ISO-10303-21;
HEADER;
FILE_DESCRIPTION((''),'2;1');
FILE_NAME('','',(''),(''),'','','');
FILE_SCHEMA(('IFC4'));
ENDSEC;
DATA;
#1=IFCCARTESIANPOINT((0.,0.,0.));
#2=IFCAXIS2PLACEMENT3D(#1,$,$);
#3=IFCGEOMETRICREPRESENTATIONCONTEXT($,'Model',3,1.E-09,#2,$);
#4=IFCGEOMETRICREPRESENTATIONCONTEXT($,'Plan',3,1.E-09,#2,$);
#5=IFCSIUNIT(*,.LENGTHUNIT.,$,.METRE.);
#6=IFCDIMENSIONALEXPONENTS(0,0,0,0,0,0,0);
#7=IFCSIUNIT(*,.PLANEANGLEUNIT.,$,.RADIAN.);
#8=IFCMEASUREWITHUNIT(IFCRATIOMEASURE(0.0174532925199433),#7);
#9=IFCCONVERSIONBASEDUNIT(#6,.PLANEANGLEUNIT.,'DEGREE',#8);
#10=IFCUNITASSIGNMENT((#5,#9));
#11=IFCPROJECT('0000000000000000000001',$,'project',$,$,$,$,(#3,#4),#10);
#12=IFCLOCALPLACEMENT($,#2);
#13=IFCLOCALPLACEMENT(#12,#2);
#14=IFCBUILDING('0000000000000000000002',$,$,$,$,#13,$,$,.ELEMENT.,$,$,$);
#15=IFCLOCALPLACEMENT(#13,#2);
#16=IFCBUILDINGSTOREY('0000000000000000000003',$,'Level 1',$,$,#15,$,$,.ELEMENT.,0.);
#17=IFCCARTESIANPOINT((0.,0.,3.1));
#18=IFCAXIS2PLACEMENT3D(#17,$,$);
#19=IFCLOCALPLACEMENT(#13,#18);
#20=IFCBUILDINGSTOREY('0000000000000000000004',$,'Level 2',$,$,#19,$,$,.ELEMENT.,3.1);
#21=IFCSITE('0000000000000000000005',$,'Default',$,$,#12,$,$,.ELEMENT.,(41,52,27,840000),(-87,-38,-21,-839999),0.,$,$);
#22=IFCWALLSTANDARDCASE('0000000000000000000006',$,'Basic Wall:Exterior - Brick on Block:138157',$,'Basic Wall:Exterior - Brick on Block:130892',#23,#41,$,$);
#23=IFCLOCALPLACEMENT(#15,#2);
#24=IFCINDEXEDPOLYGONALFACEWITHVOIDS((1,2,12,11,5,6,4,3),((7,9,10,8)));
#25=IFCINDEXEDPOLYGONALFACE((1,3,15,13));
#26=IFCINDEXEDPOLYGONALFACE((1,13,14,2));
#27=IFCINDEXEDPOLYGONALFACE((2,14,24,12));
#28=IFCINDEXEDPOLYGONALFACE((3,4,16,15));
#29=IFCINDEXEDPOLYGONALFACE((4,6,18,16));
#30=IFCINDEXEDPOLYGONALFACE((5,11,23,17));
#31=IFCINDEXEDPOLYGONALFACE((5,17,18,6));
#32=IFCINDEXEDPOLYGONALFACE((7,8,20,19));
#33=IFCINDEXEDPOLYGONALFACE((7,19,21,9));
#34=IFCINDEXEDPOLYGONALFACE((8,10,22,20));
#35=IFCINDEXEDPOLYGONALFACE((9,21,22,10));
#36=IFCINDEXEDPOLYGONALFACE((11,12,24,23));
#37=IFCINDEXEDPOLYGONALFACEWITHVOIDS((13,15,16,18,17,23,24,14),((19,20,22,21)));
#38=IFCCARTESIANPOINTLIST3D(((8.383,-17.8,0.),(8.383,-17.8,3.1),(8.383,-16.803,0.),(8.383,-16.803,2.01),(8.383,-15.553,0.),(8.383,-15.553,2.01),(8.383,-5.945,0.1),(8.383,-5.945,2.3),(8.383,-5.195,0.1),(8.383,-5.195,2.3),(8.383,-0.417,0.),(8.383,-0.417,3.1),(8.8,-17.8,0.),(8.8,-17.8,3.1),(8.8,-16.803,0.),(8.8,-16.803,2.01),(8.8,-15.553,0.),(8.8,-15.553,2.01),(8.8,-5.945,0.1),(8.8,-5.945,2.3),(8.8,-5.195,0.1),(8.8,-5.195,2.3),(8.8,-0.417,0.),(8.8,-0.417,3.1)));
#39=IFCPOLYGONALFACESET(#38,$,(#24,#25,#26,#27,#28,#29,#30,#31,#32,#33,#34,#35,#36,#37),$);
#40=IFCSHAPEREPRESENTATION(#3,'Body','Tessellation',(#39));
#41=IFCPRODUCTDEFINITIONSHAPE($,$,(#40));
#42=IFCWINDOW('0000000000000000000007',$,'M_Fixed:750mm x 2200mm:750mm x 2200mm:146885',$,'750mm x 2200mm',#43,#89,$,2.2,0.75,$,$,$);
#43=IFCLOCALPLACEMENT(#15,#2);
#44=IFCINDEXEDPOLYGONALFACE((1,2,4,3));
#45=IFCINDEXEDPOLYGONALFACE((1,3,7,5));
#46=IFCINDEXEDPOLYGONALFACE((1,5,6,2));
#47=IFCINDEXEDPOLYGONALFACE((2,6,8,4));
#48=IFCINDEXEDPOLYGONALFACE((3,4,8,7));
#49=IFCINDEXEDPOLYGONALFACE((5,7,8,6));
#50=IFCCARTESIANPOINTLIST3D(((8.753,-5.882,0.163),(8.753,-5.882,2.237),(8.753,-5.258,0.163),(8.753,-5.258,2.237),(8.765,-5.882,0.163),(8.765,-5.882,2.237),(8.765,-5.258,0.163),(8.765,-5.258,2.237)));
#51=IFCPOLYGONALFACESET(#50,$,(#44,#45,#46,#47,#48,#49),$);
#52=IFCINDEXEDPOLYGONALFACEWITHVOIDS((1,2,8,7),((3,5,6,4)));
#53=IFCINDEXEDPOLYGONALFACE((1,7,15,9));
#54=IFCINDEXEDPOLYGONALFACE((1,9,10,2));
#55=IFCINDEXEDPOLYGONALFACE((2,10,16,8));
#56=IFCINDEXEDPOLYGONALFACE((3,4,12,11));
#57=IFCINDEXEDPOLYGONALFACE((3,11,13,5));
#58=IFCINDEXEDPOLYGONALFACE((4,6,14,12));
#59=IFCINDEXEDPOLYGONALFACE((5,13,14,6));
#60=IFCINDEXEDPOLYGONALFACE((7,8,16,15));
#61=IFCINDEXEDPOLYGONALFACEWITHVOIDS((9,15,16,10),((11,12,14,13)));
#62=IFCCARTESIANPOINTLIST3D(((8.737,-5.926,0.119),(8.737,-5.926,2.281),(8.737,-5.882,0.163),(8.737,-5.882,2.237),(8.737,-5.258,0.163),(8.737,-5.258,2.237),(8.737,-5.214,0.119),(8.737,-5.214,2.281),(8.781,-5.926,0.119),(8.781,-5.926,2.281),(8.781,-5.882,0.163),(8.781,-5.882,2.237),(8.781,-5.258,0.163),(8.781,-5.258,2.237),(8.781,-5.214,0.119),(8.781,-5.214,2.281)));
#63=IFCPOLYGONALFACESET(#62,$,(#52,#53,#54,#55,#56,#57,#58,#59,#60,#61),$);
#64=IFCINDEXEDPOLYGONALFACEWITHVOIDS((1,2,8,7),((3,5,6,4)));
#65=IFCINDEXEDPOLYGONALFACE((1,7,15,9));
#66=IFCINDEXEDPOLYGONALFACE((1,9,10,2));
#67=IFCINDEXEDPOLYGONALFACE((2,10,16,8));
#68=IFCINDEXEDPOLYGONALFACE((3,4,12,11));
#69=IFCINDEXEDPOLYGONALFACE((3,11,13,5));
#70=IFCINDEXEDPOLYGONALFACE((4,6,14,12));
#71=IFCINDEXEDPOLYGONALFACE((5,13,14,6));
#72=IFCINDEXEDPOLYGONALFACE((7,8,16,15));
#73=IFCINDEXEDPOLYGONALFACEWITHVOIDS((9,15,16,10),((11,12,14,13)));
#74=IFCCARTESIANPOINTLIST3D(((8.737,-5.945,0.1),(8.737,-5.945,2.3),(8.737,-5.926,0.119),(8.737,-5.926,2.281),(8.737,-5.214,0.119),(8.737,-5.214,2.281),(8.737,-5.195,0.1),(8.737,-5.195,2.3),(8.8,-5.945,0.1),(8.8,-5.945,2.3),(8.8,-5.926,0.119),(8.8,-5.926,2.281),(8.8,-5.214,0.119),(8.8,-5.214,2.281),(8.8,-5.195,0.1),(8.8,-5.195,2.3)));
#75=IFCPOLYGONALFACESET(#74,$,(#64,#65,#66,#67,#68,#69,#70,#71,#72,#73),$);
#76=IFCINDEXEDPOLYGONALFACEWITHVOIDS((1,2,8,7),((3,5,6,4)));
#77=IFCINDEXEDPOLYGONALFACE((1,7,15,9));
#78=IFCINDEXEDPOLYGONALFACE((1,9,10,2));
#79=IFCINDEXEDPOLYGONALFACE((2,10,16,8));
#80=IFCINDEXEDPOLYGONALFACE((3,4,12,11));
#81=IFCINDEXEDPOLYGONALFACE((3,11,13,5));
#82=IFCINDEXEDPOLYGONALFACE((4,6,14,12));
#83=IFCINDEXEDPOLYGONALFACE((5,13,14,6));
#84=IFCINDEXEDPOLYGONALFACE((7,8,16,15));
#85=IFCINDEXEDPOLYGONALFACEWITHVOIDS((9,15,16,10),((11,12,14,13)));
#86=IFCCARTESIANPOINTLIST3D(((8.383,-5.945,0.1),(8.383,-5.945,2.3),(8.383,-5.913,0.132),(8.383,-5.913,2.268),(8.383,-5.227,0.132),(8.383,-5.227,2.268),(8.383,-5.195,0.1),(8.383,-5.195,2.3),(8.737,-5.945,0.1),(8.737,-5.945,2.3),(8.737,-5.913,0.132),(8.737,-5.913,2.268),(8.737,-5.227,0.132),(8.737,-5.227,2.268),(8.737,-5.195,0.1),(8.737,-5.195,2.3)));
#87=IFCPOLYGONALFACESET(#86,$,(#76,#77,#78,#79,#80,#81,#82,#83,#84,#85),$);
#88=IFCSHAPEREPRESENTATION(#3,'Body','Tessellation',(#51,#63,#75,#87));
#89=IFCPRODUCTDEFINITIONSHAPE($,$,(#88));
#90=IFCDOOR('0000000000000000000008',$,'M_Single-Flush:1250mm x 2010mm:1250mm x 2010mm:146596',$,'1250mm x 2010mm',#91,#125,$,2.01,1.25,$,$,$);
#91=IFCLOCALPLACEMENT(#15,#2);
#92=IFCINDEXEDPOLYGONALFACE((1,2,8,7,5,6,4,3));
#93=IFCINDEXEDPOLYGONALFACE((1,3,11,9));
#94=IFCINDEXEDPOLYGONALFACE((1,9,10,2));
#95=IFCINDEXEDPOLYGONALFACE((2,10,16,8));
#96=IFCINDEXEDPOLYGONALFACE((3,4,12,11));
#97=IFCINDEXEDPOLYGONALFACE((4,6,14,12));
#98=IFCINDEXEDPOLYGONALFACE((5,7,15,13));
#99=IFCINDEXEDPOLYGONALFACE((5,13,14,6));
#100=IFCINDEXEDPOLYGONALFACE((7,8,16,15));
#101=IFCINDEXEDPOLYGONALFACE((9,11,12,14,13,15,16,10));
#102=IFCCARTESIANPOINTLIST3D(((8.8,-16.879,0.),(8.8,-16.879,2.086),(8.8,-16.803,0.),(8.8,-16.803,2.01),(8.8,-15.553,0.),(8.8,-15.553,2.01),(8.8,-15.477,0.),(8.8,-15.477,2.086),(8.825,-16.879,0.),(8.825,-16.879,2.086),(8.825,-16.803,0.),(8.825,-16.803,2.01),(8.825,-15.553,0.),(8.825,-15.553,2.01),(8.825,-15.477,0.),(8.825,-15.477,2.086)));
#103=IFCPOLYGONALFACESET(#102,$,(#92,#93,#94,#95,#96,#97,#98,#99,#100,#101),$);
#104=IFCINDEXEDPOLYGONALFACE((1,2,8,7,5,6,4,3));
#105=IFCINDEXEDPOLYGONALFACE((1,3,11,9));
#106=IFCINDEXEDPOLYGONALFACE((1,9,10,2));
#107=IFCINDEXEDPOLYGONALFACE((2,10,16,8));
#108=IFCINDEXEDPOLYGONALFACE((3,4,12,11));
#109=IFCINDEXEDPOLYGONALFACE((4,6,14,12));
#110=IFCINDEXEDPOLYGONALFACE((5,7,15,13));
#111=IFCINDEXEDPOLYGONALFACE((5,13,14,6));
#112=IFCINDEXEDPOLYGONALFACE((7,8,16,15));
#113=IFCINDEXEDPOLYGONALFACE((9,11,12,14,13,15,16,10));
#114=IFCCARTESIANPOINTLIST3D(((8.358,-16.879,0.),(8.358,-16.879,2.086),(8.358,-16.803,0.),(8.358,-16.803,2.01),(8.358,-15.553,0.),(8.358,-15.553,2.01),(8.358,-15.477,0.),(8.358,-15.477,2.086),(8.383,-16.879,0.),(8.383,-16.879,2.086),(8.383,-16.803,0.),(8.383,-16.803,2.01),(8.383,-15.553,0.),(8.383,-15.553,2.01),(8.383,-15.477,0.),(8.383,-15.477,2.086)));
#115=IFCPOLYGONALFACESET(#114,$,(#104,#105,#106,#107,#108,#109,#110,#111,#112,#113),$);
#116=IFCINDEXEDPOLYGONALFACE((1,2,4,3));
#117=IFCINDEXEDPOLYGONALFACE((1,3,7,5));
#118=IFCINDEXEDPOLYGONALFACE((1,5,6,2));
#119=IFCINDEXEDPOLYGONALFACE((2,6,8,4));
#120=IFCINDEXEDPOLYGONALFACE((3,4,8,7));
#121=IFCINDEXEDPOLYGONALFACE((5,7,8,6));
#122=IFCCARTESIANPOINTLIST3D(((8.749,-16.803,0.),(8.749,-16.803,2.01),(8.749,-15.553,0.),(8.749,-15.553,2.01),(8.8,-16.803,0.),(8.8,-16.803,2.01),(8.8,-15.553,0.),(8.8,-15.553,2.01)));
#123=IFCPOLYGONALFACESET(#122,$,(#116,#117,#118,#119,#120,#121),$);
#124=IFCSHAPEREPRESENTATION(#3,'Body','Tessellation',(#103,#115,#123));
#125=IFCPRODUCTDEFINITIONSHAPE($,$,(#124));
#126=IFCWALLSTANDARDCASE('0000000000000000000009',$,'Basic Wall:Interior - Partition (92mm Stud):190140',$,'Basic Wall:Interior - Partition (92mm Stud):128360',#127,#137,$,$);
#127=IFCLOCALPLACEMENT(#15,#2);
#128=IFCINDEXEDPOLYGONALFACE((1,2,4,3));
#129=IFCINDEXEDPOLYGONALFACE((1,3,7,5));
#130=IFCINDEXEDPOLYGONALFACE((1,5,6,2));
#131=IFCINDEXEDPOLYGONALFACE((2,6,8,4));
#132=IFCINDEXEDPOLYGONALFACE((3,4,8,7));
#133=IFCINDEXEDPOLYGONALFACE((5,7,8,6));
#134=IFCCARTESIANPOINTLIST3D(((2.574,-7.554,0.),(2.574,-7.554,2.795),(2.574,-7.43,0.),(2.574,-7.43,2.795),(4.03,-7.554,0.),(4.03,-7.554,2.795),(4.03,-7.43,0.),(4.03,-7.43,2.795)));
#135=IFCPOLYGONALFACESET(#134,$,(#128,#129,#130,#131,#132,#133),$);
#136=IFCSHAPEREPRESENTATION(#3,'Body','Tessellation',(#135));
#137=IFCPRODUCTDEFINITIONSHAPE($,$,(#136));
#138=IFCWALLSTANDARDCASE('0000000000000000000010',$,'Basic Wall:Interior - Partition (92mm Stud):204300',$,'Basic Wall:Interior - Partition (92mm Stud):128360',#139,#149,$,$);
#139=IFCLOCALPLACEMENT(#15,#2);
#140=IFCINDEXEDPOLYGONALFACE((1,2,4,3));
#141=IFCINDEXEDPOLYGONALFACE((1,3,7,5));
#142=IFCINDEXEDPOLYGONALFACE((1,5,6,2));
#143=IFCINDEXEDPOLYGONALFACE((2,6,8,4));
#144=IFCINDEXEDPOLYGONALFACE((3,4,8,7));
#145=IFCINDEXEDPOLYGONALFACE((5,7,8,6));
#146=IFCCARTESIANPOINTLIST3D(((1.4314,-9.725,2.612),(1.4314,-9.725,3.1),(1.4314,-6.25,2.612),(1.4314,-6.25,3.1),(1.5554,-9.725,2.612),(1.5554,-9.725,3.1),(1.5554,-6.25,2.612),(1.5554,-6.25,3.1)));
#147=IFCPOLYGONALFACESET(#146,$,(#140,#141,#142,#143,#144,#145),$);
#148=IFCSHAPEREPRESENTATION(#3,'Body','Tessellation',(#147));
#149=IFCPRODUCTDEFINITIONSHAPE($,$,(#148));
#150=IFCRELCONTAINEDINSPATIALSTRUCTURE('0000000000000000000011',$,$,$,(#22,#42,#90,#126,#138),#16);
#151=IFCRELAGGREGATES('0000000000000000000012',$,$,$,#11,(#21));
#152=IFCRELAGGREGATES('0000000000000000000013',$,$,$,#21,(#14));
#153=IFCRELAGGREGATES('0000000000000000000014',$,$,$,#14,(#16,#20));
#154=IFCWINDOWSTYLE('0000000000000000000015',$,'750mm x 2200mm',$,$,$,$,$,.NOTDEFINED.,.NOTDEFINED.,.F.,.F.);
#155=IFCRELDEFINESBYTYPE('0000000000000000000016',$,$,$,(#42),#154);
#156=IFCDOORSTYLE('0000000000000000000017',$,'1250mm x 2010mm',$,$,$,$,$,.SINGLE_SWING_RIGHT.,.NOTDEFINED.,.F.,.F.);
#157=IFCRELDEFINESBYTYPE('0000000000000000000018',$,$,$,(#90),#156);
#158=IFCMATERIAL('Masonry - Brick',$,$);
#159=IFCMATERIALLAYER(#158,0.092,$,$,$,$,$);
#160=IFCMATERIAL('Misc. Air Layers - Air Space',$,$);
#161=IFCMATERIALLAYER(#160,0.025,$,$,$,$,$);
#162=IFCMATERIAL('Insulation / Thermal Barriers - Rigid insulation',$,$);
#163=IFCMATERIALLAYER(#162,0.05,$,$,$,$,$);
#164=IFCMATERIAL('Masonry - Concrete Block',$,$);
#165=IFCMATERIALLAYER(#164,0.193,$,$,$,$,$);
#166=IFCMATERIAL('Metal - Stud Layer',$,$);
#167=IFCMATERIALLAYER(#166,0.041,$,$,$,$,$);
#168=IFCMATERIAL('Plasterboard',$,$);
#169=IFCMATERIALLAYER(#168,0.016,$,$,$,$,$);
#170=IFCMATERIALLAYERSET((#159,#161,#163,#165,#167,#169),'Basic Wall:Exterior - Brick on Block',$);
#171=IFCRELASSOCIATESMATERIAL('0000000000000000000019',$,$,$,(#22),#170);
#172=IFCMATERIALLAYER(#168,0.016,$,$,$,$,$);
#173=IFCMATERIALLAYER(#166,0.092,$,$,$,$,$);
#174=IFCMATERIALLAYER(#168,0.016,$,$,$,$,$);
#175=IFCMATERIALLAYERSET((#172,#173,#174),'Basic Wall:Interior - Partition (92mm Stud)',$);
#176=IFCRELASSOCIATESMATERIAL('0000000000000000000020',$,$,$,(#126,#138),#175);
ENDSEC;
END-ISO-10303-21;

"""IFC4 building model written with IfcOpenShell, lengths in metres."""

from ifc_helpers import new_model, entity, si_unit, converted_unit, frame, frame_2d, origin, origin_2d_with_axis, place, context, project, spatial, polyline, rectangle, outline, extrude, source, transform, mapped, material, layer, layer_set, layer_usage, type_object, type_shapes, element, fill, save


model = new_model("IFC4")

# Units and contexts
model_context = context("Model", 3, precision=1e-09, world=origin())
plan_context = context("Plan", 3, precision=1e-09, world=origin())
ifc_project = project(units=[si_unit("LENGTHUNIT", "METRE"), converted_unit("PLANEANGLEUNIT", "DEGREE", entity("IfcRatioMeasure", 0.0174532925199433), si_unit("PLANEANGLEUNIT", "RADIAN"), dimensions=[0, 0, 0, 0, 0, 0, 0])], contexts=[model_context, plan_context])

# Site, building, storey
site_placement = place(None, origin())
site = spatial("IfcSite", under=ifc_project, at=site_placement, Name="Default", CompositionType="ELEMENT", RefLatitude=(41, 52, 27, 840000), RefLongitude=(-87, -38, -21, -839999), RefElevation=0.0)
building_placement = place(site_placement, origin())
building = spatial("IfcBuilding", under=site, at=building_placement, CompositionType="ELEMENT")
storey_1_placement = place(building_placement, origin())
storey_1 = spatial("IfcBuildingStorey", under=building, at=storey_1_placement, Name="Level 1", CompositionType="ELEMENT", Elevation=0.0)

# Shared definitions
ifc_material_1 = material(Name="Metal - Stud Layer")
ifc_material_2 = material(Name="Plasterboard")
ifc_material_3 = material(Name="Masonry - Concrete Block")
ifc_material_4 = material(Name="Misc. Air Layers - Air Space")

# Wall, openings, window, door
ifc_material_5 = material(Name="Masonry - Brick")
ifc_layer_1 = layer(ifc_material_5, 0.092)
ifc_layer_2 = layer(ifc_material_4, 0.025)
ifc_material_6 = material(Name="Insulation / Thermal Barriers - Rigid insulation")
ifc_layer_3 = layer(ifc_material_6, 0.05)
ifc_layer_4 = layer(ifc_material_3, 0.193)
ifc_layer_5 = layer(ifc_material_1, 0.041)
ifc_layer_6 = layer(ifc_material_2, 0.016)
ifc_layer_set_1 = layer_set([ifc_layer_1, ifc_layer_2, ifc_layer_3, ifc_layer_4, ifc_layer_5, ifc_layer_6], Name="Basic Wall:Exterior - Brick on Block")
ifc_layer_usage_1 = layer_usage(ifc_layer_set_1, "AXIS2", "NEGATIVE", 0.2085)
wall_1_placement = place(storey_1_placement, frame((8.5915, -0.417, 0.0), z_axis=(0.0, 0.0, 1.0), x_axis=(0.0, -1.0, 0.0)))
wall_1 = element("IfcWallStandardCase", 1, at=wall_1_placement, inside=storey_1, material=ifc_layer_usage_1, Name="Basic Wall:Exterior - Brick on Block:138157", ObjectType="Basic Wall:Exterior - Brick on Block:130892", context=model_context, shape_type="SweptSolid", body=[
    extrude(rectangle(XDim=17.383, YDim=0.417, at=frame_2d((8.6915, 0.0), x_axis=(-1.0, 0.0))), origin(), (0.0, 0.0, 1.0), 3.1),
])
opening_1_placement = place(wall_1_placement, frame((4.778, -0.2085, 0.1)))
opening_1 = element("IfcOpeningElement", 2, at=opening_1_placement, cuts=wall_1, ObjectType="Opening", context=model_context, shape_type="SweptSolid", body=[
    extrude(rectangle(XDim=2.2, YDim=0.75, at=frame_2d((1.1, 0.375), x_axis=(1.0, 0.0))), frame((0.0, 0.0, 0.0), z_axis=(0.0, 1.0, 0.0), x_axis=(0.0, 0.0, 1.0)), (0.0, 0.0, 1.0), 0.417),
])
opening_2_placement = place(wall_1_placement, frame((15.136, -0.2085, 0.0)))
opening_2 = element("IfcOpeningElement", 3, at=opening_2_placement, cuts=wall_1, ObjectType="Opening", context=model_context, shape_type="SweptSolid", body=[
    extrude(rectangle(XDim=1.25, YDim=2.01, at=frame_2d((1.005, 0.625), x_axis=(0.0, 1.0))), frame((0.0, 0.0, 0.0), z_axis=(0.0, 1.0, 0.0), x_axis=(0.0, 0.0, 1.0)), (0.0, 0.0, 1.0), 0.417),
])
window_style_1 = type_object("IfcWindowStyle", Name="750mm x 2200mm", ConstructionType="NOTDEFINED", OperationType="NOTDEFINED", ParameterTakesPrecedence=False, Sizeable=False)
shared_shape_1 = source(origin(), model_context, "Body", "SweptSolid", [
    extrude(rectangle(XDim=0.012, YDim=0.624, at=origin_2d_with_axis()), frame((0.375, 0.376, 0.063), z_axis=(0.0, 0.0, 1.0), x_axis=(0.0, -1.0, 0.0)), (0.0, 0.0, 1.0), 2.074),
    extrude(outline(polyline([(-0.356, -1.081), (0.356, -1.081), (0.356, 1.081), (-0.356, 1.081), (-0.356, -1.081)]), holes=[polyline([(-0.312, -1.037), (-0.312, 1.037), (0.312, 1.037), (0.312, -1.037), (-0.312, -1.037)])]), frame((0.375, 0.354, 1.1), z_axis=(0.0, 1.0, 0.0), x_axis=(1.0, 0.0, 0.0)), (0.0, 0.0, 1.0), 0.044),
    extrude(outline(polyline([(-0.375, -1.1), (0.375, -1.1), (0.375, 1.1), (-0.375, 1.1), (-0.375, -1.1)]), holes=[polyline([(-0.356, -1.081), (-0.356, 1.081), (0.356, 1.081), (0.356, -1.081), (-0.356, -1.081)])]), frame((0.375, 0.354, 1.1), z_axis=(0.0, 1.0, 0.0), x_axis=(1.0, 0.0, 0.0)), (0.0, 0.0, 1.0), 0.063),
    extrude(outline(polyline([(-0.375, -1.1), (0.375, -1.1), (0.375, 1.1), (-0.375, 1.1), (-0.375, -1.1)]), holes=[polyline([(-0.343, -1.068), (-0.343, 1.068), (0.343, 1.068), (0.343, -1.068), (-0.343, -1.068)])]), frame((0.375, 0.0, 1.1), z_axis=(0.0, 1.0, 0.0), x_axis=(1.0, 0.0, 0.0)), (0.0, 0.0, 1.0), 0.354),
])
type_shapes(window_style_1, [shared_shape_1])
window_1_placement = place(opening_1_placement, origin())
window_1 = element("IfcWindow", 4, at=window_1_placement, inside=storey_1, type_object=window_style_1, Name="M_Fixed:750mm x 2200mm:750mm x 2200mm:146885", ObjectType="750mm x 2200mm", OverallHeight=2.2, OverallWidth=0.75, context=model_context, shape_type="MappedRepresentation", body=[
    mapped(shared_shape_1, transform((0.0, 0.0, 0.0), scale=1.0)),
])
fill(opening_1, window_1)
door_style_1 = type_object("IfcDoorStyle", Name="1250mm x 2010mm", ConstructionType="NOTDEFINED", OperationType="SINGLE_SWING_RIGHT", ParameterTakesPrecedence=False, Sizeable=False)
shared_shape_2 = source(origin(), model_context, "Body", "SweptSolid", [
    extrude(outline(polyline([(-0.701, -1.062), (0.701, -1.062), (0.701, 1.024), (0.625, 1.024), (0.625, -0.986), (-0.625, -0.986), (-0.625, 1.024), (-0.701, 1.024), (-0.701, -1.062)])), frame((0.625, 0.417, 1.024), z_axis=(0.0, 1.0, 0.0), x_axis=(1.0, 0.0, 0.0)), (0.0, 0.0, 1.0), 0.025),
    extrude(outline(polyline([(-1.062, -0.701), (1.024, -0.701), (1.024, -0.625), (-0.986, -0.625), (-0.986, 0.625), (1.024, 0.625), (1.024, 0.701), (-1.062, 0.701), (-1.062, -0.701)])), frame((0.625, -0.025, 1.024), z_axis=(0.0, 1.0, 0.0), x_axis=(0.0, 0.0, -1.0)), (0.0, 0.0, 1.0), 0.025),
    extrude(rectangle(XDim=0.051, YDim=1.25, at=origin_2d_with_axis()), frame((0.625, 0.3915, 0.0), z_axis=(0.0, 0.0, 1.0), x_axis=(0.0, 1.0, 0.0)), (0.0, 0.0, 1.0), 2.01),
])
type_shapes(door_style_1, [shared_shape_2])
door_1_placement = place(opening_2_placement, origin())
door_1 = element("IfcDoor", 5, at=door_1_placement, inside=storey_1, type_object=door_style_1, Name="M_Single-Flush:1250mm x 2010mm:1250mm x 2010mm:146596", ObjectType="1250mm x 2010mm", OverallHeight=2.01, OverallWidth=1.25, context=model_context, shape_type="MappedRepresentation", body=[
    mapped(shared_shape_2, transform((0.0, 0.0, 0.0), scale=1.0)),
])
fill(opening_2, door_1)

# Wall
ifc_layer_7 = layer(ifc_material_2, 0.016)
ifc_layer_8 = layer(ifc_material_1, 0.092)
ifc_layer_9 = layer(ifc_material_2, 0.016)
ifc_layer_set_2 = layer_set([ifc_layer_7, ifc_layer_8, ifc_layer_9], Name="Basic Wall:Interior - Partition (92mm Stud)")
ifc_layer_usage_2 = layer_usage(ifc_layer_set_2, "AXIS2", "NEGATIVE", 0.062)
wall_2_placement = place(storey_1_placement, frame((4.03, -7.492, 0.0), z_axis=(0.0, 0.0, 1.0), x_axis=(-1.0, 0.0, 0.0)))
element("IfcWallStandardCase", 6, at=wall_2_placement, inside=storey_1, material=ifc_layer_usage_2, Name="Basic Wall:Interior - Partition (92mm Stud):190140", ObjectType="Basic Wall:Interior - Partition (92mm Stud):128360", context=model_context, shape_type="SweptSolid", body=[
    extrude(rectangle(XDim=1.456, YDim=0.124, at=frame_2d((0.728, 0.0), x_axis=(-1.0, 0.0))), origin(), (0.0, 0.0, 1.0), 2.795),
])

# Shared definitions
storey_2_placement = place(building_placement, frame((0.0, 0.0, 3.1)))
storey_2 = spatial("IfcBuildingStorey", under=building, at=storey_2_placement, Name="Level 2", CompositionType="ELEMENT", Elevation=3.1)

# Wall
ifc_layer_usage_3 = layer_usage(ifc_layer_set_2, "AXIS2", "NEGATIVE", 0.062)
wall_3_placement = place(storey_1_placement, frame((1.4934, -6.25, 2.612), z_axis=(0.0, 0.0, 1.0), x_axis=(0.0, -1.0, 0.0)))
element("IfcWallStandardCase", 7, at=wall_3_placement, inside=storey_1, material=ifc_layer_usage_3, Name="Basic Wall:Interior - Partition (92mm Stud):204300", ObjectType="Basic Wall:Interior - Partition (92mm Stud):128360", context=model_context, shape_type="SweptSolid", body=[
    extrude(rectangle(XDim=3.475, YDim=0.124, at=frame_2d((1.7375, 0.0), x_axis=(-1.0, 0.0))), origin(), (0.0, 0.0, 1.0), 0.488),
])

save(model, "model.ifc")
